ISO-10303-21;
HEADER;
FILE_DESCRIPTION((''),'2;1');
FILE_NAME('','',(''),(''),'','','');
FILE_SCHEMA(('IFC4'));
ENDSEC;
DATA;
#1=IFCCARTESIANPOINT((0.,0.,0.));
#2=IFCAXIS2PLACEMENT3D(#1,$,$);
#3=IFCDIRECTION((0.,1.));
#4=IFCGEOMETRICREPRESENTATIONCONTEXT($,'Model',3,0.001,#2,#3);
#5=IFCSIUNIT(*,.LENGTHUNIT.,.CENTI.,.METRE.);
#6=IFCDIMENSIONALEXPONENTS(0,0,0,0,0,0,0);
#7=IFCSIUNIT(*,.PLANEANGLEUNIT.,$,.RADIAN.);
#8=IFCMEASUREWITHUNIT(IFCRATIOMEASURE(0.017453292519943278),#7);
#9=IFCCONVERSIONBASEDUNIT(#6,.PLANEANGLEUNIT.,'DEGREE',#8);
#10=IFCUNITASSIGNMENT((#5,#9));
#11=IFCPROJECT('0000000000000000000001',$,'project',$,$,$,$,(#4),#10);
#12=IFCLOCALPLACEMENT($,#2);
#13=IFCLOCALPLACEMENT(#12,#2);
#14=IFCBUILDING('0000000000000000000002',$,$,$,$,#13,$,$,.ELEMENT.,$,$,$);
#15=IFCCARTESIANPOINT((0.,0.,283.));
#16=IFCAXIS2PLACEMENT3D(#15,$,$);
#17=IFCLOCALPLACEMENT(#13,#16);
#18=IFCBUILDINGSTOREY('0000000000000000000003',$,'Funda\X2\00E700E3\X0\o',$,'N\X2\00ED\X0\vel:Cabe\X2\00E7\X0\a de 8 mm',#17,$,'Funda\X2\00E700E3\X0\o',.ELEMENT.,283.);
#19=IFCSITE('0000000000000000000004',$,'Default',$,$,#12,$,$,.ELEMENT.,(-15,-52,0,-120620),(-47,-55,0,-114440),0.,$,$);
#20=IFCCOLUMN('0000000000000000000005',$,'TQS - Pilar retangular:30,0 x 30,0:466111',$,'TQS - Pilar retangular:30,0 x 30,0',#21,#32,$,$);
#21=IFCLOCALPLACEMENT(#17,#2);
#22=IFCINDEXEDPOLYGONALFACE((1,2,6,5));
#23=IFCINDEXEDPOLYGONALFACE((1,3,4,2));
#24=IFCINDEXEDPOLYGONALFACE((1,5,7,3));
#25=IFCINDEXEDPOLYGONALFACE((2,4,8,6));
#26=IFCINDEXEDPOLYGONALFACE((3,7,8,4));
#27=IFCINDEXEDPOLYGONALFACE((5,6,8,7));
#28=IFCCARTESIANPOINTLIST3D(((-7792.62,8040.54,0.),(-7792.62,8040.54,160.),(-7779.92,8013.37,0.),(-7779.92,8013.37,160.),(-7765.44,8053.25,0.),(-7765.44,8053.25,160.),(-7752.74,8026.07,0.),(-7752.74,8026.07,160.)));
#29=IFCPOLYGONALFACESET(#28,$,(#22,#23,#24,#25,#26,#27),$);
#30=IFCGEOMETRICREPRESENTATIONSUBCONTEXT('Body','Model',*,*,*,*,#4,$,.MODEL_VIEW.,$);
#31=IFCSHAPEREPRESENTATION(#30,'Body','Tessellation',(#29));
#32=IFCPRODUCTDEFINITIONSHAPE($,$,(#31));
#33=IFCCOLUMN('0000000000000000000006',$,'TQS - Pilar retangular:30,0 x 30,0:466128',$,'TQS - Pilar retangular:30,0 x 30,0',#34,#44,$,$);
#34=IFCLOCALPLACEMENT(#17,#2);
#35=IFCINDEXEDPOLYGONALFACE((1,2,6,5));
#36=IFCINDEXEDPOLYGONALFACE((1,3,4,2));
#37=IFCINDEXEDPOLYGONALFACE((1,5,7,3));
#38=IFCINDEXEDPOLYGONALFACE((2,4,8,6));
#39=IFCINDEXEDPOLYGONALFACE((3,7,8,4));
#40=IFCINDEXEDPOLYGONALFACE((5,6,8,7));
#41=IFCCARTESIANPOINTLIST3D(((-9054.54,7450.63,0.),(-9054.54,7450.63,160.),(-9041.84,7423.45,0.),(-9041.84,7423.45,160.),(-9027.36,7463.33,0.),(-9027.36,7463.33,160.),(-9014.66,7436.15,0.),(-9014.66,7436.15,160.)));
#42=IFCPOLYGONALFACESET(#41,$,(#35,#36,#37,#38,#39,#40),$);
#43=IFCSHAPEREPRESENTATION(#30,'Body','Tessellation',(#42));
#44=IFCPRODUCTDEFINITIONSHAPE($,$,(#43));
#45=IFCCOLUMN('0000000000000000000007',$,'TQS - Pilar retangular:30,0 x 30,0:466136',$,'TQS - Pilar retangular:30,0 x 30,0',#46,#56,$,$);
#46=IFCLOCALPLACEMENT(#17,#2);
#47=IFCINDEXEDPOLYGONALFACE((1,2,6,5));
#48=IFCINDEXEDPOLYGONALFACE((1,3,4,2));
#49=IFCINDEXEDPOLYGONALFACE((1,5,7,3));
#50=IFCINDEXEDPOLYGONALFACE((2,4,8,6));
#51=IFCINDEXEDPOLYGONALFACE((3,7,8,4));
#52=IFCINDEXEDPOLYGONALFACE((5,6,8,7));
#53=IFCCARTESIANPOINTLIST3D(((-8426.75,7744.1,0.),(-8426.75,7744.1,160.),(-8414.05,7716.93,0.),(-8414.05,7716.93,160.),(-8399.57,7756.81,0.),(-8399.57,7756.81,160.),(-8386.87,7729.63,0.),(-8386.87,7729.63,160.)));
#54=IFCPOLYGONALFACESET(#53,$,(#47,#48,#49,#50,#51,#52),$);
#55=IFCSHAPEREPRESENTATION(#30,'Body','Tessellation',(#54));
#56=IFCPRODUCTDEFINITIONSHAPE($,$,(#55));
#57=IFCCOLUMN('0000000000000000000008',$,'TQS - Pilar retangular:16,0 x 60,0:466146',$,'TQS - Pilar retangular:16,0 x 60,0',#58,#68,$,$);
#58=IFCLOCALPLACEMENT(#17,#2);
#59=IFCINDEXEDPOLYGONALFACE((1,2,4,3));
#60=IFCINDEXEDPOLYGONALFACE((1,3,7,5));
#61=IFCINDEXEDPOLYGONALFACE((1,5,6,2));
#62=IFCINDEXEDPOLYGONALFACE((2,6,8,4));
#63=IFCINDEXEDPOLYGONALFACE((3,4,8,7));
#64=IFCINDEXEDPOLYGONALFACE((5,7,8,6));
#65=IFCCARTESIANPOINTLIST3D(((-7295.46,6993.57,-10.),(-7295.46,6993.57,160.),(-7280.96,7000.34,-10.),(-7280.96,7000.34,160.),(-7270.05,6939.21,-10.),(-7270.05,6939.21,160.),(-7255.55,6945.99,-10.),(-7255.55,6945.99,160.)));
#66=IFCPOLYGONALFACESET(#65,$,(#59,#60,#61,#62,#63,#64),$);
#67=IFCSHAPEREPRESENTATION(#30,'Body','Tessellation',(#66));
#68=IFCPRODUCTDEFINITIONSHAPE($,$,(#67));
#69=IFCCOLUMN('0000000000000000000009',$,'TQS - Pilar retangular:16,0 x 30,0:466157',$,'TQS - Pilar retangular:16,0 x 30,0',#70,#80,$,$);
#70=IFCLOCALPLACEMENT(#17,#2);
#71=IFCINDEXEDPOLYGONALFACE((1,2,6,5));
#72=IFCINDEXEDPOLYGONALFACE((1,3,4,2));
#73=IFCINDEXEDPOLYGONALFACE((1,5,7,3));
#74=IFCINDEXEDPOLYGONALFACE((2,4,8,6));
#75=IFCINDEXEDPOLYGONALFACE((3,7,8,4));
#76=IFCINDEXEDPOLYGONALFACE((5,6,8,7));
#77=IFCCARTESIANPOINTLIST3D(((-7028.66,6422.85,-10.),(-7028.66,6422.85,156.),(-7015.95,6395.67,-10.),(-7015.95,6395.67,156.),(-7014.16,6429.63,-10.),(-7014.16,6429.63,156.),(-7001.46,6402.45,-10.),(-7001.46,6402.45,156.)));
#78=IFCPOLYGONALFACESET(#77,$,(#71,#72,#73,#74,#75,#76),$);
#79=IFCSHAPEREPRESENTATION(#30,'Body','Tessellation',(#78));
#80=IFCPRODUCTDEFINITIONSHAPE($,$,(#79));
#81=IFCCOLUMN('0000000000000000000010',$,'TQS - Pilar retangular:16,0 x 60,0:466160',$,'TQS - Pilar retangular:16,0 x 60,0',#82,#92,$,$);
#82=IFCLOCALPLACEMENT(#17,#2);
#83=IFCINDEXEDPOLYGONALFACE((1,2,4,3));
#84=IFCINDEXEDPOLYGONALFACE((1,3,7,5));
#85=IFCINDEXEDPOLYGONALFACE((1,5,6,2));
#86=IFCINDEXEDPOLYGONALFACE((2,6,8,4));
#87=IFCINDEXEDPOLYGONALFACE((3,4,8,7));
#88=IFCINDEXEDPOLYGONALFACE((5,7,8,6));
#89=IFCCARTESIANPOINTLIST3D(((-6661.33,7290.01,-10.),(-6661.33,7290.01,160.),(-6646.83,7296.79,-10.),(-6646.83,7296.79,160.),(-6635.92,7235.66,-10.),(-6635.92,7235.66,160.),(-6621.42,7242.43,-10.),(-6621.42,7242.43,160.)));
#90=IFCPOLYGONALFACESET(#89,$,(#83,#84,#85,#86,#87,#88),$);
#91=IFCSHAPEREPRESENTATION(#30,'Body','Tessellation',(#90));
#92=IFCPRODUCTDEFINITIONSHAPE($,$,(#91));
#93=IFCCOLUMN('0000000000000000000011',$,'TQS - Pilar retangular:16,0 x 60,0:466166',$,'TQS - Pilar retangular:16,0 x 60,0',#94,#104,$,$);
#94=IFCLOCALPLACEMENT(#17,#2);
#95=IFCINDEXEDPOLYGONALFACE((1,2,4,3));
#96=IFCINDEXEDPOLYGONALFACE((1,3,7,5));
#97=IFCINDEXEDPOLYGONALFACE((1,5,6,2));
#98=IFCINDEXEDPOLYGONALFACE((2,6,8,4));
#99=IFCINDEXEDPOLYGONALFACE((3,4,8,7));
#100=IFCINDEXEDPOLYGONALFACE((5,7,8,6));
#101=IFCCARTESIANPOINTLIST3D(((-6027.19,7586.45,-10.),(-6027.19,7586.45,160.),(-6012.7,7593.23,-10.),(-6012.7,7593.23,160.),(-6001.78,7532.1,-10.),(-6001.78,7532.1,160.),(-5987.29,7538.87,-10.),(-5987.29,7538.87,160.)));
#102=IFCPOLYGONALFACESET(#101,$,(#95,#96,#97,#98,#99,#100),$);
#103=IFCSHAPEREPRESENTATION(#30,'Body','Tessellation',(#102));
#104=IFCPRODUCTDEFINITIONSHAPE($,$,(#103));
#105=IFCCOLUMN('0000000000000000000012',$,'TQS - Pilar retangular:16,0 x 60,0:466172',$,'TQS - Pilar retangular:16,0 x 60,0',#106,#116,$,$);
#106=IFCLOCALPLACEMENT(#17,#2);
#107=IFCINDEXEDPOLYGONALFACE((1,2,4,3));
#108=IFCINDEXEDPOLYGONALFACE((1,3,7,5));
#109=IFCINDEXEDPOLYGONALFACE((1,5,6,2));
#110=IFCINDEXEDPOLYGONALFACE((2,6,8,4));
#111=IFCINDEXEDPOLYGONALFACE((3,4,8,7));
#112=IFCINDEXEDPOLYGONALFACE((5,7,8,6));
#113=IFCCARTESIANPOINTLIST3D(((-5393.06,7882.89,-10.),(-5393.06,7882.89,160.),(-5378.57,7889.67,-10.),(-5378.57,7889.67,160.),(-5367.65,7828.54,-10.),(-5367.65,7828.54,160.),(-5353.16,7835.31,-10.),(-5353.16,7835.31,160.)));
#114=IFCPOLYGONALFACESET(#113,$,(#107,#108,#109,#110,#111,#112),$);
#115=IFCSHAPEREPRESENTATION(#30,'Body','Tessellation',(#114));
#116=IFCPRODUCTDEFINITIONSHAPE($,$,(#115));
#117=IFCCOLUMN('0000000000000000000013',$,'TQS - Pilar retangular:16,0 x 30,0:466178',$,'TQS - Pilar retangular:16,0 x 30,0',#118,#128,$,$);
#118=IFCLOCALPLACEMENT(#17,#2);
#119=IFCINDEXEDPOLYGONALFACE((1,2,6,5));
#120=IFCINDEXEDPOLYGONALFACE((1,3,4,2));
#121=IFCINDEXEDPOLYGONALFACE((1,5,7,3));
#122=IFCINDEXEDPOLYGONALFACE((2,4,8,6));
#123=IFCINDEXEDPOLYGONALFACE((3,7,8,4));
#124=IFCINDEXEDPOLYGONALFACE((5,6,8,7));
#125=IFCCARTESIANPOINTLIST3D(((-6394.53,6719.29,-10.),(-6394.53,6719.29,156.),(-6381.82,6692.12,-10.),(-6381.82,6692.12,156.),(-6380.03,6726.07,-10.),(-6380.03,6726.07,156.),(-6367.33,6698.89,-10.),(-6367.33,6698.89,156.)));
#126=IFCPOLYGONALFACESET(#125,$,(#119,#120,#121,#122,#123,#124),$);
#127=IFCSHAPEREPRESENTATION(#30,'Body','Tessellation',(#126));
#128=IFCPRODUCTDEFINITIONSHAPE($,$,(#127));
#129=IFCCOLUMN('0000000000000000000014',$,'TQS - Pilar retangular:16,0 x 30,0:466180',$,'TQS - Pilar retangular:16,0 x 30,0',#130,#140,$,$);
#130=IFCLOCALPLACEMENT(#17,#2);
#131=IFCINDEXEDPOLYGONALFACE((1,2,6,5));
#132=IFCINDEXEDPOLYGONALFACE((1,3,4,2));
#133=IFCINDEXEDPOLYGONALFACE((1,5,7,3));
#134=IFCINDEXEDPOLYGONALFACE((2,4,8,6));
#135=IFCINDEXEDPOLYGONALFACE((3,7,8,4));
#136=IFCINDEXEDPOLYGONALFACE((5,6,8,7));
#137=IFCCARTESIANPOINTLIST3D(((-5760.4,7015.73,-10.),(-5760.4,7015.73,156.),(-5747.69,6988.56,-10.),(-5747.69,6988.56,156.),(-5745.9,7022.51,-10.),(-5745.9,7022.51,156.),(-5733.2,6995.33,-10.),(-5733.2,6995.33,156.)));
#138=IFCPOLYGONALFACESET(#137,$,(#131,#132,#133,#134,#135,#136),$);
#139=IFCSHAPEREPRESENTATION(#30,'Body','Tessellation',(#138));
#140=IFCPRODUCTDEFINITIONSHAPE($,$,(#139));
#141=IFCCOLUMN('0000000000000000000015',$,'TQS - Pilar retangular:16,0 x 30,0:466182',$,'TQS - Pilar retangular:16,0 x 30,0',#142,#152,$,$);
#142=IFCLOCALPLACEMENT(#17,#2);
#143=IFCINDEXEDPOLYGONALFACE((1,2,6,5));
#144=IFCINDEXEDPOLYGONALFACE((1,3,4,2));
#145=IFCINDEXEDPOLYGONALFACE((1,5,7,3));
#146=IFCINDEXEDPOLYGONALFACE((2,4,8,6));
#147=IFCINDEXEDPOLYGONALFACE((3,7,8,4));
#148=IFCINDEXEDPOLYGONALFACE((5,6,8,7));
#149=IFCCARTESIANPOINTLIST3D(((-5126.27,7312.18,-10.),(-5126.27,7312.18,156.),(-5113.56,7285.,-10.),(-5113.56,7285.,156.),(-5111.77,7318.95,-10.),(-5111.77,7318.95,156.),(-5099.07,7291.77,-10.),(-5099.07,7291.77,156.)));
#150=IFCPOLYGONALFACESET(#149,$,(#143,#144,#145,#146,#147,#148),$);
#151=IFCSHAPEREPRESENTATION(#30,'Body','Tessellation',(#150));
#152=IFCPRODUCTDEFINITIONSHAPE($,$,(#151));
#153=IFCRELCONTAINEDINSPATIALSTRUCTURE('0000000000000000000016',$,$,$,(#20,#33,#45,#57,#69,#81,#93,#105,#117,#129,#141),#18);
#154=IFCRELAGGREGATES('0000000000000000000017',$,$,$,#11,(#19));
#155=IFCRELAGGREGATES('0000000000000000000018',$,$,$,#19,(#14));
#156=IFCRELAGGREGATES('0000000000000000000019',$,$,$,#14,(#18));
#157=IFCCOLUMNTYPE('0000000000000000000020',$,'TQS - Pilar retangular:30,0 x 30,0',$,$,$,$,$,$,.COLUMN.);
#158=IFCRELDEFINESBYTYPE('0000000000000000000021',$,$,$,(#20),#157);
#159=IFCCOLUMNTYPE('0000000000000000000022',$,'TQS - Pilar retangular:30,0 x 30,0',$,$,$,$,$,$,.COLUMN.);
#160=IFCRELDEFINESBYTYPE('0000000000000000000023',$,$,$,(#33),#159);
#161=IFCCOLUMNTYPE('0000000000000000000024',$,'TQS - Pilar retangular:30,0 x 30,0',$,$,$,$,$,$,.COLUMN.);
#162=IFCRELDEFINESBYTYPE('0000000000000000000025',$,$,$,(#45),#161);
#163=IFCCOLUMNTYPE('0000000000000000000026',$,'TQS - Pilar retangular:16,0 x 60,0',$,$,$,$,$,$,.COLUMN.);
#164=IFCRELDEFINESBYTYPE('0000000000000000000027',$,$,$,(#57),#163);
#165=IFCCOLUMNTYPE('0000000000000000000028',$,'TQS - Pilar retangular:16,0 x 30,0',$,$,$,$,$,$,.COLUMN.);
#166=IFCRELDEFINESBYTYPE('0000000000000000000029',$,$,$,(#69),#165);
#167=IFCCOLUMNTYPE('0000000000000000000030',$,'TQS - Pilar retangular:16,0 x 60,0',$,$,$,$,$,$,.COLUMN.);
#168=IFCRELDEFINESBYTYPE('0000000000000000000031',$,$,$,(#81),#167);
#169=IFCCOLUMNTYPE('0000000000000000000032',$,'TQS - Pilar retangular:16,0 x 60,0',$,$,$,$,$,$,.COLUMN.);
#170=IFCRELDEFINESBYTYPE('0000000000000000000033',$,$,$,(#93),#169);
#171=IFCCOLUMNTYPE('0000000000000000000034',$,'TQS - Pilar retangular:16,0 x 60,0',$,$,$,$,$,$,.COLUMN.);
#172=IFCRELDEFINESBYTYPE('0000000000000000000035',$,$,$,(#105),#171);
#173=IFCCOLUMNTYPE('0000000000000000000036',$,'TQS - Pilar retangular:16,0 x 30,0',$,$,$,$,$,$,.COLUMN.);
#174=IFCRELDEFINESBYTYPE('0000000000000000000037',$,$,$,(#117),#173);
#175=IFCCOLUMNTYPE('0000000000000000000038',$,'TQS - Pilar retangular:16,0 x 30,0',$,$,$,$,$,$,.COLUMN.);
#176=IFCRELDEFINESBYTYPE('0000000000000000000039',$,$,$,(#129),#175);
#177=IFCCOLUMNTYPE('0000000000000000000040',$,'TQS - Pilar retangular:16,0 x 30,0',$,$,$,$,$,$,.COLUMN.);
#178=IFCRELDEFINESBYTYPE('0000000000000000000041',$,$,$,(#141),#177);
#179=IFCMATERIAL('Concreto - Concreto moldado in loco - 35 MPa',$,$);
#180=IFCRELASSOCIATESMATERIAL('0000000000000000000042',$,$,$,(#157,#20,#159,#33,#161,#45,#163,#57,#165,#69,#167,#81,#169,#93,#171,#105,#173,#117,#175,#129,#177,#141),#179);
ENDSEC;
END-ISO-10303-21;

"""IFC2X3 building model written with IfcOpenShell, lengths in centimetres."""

from ifc_helpers import new_model, entity, si_unit, converted_unit, direction, frame, frame_2d, origin, origin_2d_with_axis, place, context, subcontext, project, spatial, rectangle, extrude, source, transform, mapped, material, type_object, type_shapes, element, save


model = new_model("IFC2X3")

# Units and contexts
model_context = context("Model", 3, precision=0.001, world=origin(), true_north=direction((0.0, 1.0)))
body_context = subcontext(model_context, "Body", "Model", "MODEL_VIEW")
ifc_project = project(units=[si_unit("LENGTHUNIT", "METRE", prefix="CENTI"), converted_unit("PLANEANGLEUNIT", "DEGREE", entity("IfcRatioMeasure", 0.017453292519943278), si_unit("PLANEANGLEUNIT", "RADIAN"), dimensions=[0, 0, 0, 0, 0, 0, 0])], contexts=[model_context])

# Site, building, storey
site_placement = place(None, origin())
site = spatial("IfcSite", under=ifc_project, at=site_placement, Name="Default", CompositionType="ELEMENT", RefLatitude=(-15, -52, 0, -120620), RefLongitude=(-47, -55, 0, -114440), RefElevation=0.0)
building_placement = place(site_placement, origin())
building = spatial("IfcBuilding", under=site, at=building_placement, CompositionType="ELEMENT")
storey_placement = place(building_placement, frame((0.0, 0.0, 283.0)))
storey = spatial("IfcBuildingStorey", under=building, at=storey_placement, Name="Fundação", ObjectType="Nível:Cabeça de 8 mm", LongName="Fundação", CompositionType="ELEMENT", Elevation=283.0)

# Columns
ifc_material_1 = material(Name="Concreto - Concreto moldado in loco - 35 MPa")
column_type_1 = type_object("IfcColumnType", Name="TQS - Pilar retangular:30,0 x 30,0", PredefinedType="COLUMN", material=ifc_material_1)
shared_shape_1 = source(origin(), body_context, "Body", "SweptSolid", [
    extrude(rectangle(XDim=30.0, YDim=30.0, at=origin_2d_with_axis()), frame((-7772.68, 8033.31, 283.0), z_axis=(0.0, 0.0, 1.0), x_axis=(-0.423488, 0.905902, 0.0)), (0.0, 0.0, 1.0), 160.0),
])
type_shapes(column_type_1, [shared_shape_1])
column_1_placement = place(storey_placement, frame((0.0, 0.0, -283.0)))
element("IfcColumn", 1, at=column_1_placement, inside=storey, type_object=column_type_1, material=ifc_material_1, Name="TQS - Pilar retangular:30,0 x 30,0:466111", ObjectType="TQS - Pilar retangular:30,0 x 30,0", context=body_context, shape_type="MappedRepresentation", body=[
    mapped(shared_shape_1, transform((0.0, 0.0, 0.0), scale=1.0)),
])
column_type_2 = type_object("IfcColumnType", Name="TQS - Pilar retangular:30,0 x 30,0", PredefinedType="COLUMN", material=ifc_material_1)
shared_shape_2 = source(origin(), body_context, "Body", "SweptSolid", [
    extrude(rectangle(XDim=30.0, YDim=30.0, at=origin_2d_with_axis()), frame((-9034.6, 7443.39, 283.0), z_axis=(0.0, 0.0, 1.0), x_axis=(-0.423488, 0.905902, 0.0)), (0.0, 0.0, 1.0), 160.0),
])
type_shapes(column_type_2, [shared_shape_2])
column_2_placement = place(storey_placement, frame((0.0, 0.0, -283.0)))
element("IfcColumn", 2, at=column_2_placement, inside=storey, type_object=column_type_2, material=ifc_material_1, Name="TQS - Pilar retangular:30,0 x 30,0:466128", ObjectType="TQS - Pilar retangular:30,0 x 30,0", context=body_context, shape_type="MappedRepresentation", body=[
    mapped(shared_shape_2, transform((0.0, 0.0, 0.0), scale=1.0)),
])
column_type_3 = type_object("IfcColumnType", Name="TQS - Pilar retangular:30,0 x 30,0", PredefinedType="COLUMN", material=ifc_material_1)
shared_shape_3 = source(origin(), body_context, "Body", "SweptSolid", [
    extrude(rectangle(XDim=30.0, YDim=30.0, at=origin_2d_with_axis()), frame((-8406.81, 7736.87, 283.0), z_axis=(0.0, 0.0, 1.0), x_axis=(-0.423488, 0.905902, 0.0)), (0.0, 0.0, 1.0), 160.0),
])
type_shapes(column_type_3, [shared_shape_3])
column_3_placement = place(storey_placement, frame((0.0, 0.0, -283.0)))
element("IfcColumn", 3, at=column_3_placement, inside=storey, type_object=column_type_3, material=ifc_material_1, Name="TQS - Pilar retangular:30,0 x 30,0:466136", ObjectType="TQS - Pilar retangular:30,0 x 30,0", context=body_context, shape_type="MappedRepresentation", body=[
    mapped(shared_shape_3, transform((0.0, 0.0, 0.0), scale=1.0)),
])
column_type_4 = type_object("IfcColumnType", Name="TQS - Pilar retangular:16,0 x 60,0", PredefinedType="COLUMN", material=ifc_material_1)
shared_shape_4 = source(origin(), body_context, "Body", "SweptSolid", [
    extrude(rectangle(XDim=60.0, YDim=16.0, at=frame_2d((0.0, 0.0), x_axis=(1.0, 0.0))), frame((-7275.5, 6969.78, 273.0), z_axis=(0.0, 0.0, 1.0), x_axis=(-0.423488, 0.905902, 0.0)), (0.0, 0.0, 1.0), 170.0),
])
type_shapes(column_type_4, [shared_shape_4])
column_4_placement = place(storey_placement, frame((0.0, 0.0, -283.0)))
element("IfcColumn", 4, at=column_4_placement, inside=storey, type_object=column_type_4, material=ifc_material_1, Name="TQS - Pilar retangular:16,0 x 60,0:466146", ObjectType="TQS - Pilar retangular:16,0 x 60,0", context=body_context, shape_type="MappedRepresentation", body=[
    mapped(shared_shape_4, transform((0.0, 0.0, 0.0), scale=1.0)),
])
column_type_5 = type_object("IfcColumnType", Name="TQS - Pilar retangular:16,0 x 30,0", PredefinedType="COLUMN", material=ifc_material_1)
shared_shape_5 = source(origin(), body_context, "Body", "SweptSolid", [
    extrude(rectangle(XDim=30.0, YDim=16.0, at=frame_2d((0.0, 0.0), x_axis=(1.0, 0.0))), frame((-7015.06, 6412.65, 273.0), z_axis=(0.0, 0.0, 1.0), x_axis=(-0.423488, 0.905902, 0.0)), (0.0, 0.0, 1.0), 166.0),
])
type_shapes(column_type_5, [shared_shape_5])
column_5_placement = place(storey_placement, frame((0.0, 0.0, -283.0)))
element("IfcColumn", 5, at=column_5_placement, inside=storey, type_object=column_type_5, material=ifc_material_1, Name="TQS - Pilar retangular:16,0 x 30,0:466157", ObjectType="TQS - Pilar retangular:16,0 x 30,0", context=body_context, shape_type="MappedRepresentation", body=[
    mapped(shared_shape_5, transform((0.0, 0.0, 0.0), scale=1.0)),
])
column_type_6 = type_object("IfcColumnType", Name="TQS - Pilar retangular:16,0 x 60,0", PredefinedType="COLUMN", material=ifc_material_1)
shared_shape_6 = source(origin(), body_context, "Body", "SweptSolid", [
    extrude(rectangle(XDim=60.0, YDim=16.0, at=frame_2d((0.0, 0.0), x_axis=(1.0, 0.0))), frame((-6641.37, 7266.22, 273.0), z_axis=(0.0, 0.0, 1.0), x_axis=(-0.423488, 0.905902, 0.0)), (0.0, 0.0, 1.0), 170.0),
])
type_shapes(column_type_6, [shared_shape_6])
column_6_placement = place(storey_placement, frame((0.0, 0.0, -283.0)))
element("IfcColumn", 6, at=column_6_placement, inside=storey, type_object=column_type_6, material=ifc_material_1, Name="TQS - Pilar retangular:16,0 x 60,0:466160", ObjectType="TQS - Pilar retangular:16,0 x 60,0", context=body_context, shape_type="MappedRepresentation", body=[
    mapped(shared_shape_6, transform((0.0, 0.0, 0.0), scale=1.0)),
])
column_type_7 = type_object("IfcColumnType", Name="TQS - Pilar retangular:16,0 x 60,0", PredefinedType="COLUMN", material=ifc_material_1)
shared_shape_7 = source(origin(), body_context, "Body", "SweptSolid", [
    extrude(rectangle(XDim=60.0, YDim=16.0, at=origin_2d_with_axis()), frame((-6007.24, 7562.66, 273.0), z_axis=(0.0, 0.0, 1.0), x_axis=(-0.423488, 0.905902, 0.0)), (0.0, 0.0, 1.0), 170.0),
])
type_shapes(column_type_7, [shared_shape_7])
column_7_placement = place(storey_placement, frame((0.0, 0.0, -283.0)))
element("IfcColumn", 7, at=column_7_placement, inside=storey, type_object=column_type_7, material=ifc_material_1, Name="TQS - Pilar retangular:16,0 x 60,0:466166", ObjectType="TQS - Pilar retangular:16,0 x 60,0", context=body_context, shape_type="MappedRepresentation", body=[
    mapped(shared_shape_7, transform((0.0, 0.0, 0.0), scale=1.0)),
])
column_type_8 = type_object("IfcColumnType", Name="TQS - Pilar retangular:16,0 x 60,0", PredefinedType="COLUMN", material=ifc_material_1)
shared_shape_8 = source(origin(), body_context, "Body", "SweptSolid", [
    extrude(rectangle(XDim=60.0, YDim=16.0, at=origin_2d_with_axis()), frame((-5373.11, 7859.1, 273.0), z_axis=(0.0, 0.0, 1.0), x_axis=(-0.423488, 0.905902, 0.0)), (0.0, 0.0, 1.0), 170.0),
])
type_shapes(column_type_8, [shared_shape_8])
column_8_placement = place(storey_placement, frame((0.0, 0.0, -283.0)))
element("IfcColumn", 8, at=column_8_placement, inside=storey, type_object=column_type_8, material=ifc_material_1, Name="TQS - Pilar retangular:16,0 x 60,0:466172", ObjectType="TQS - Pilar retangular:16,0 x 60,0", context=body_context, shape_type="MappedRepresentation", body=[
    mapped(shared_shape_8, transform((0.0, 0.0, 0.0), scale=1.0)),
])
column_type_9 = type_object("IfcColumnType", Name="TQS - Pilar retangular:16,0 x 30,0", PredefinedType="COLUMN", material=ifc_material_1)
shared_shape_9 = source(origin(), body_context, "Body", "SweptSolid", [
    extrude(rectangle(XDim=30.0, YDim=16.0, at=frame_2d((0.0, 0.0), x_axis=(1.0, 0.0))), frame((-6380.93, 6709.09, 273.0), z_axis=(0.0, 0.0, 1.0), x_axis=(-0.423488, 0.905902, 0.0)), (0.0, 0.0, 1.0), 166.0),
])
type_shapes(column_type_9, [shared_shape_9])
column_9_placement = place(storey_placement, frame((0.0, 0.0, -283.0)))
element("IfcColumn", 9, at=column_9_placement, inside=storey, type_object=column_type_9, material=ifc_material_1, Name="TQS - Pilar retangular:16,0 x 30,0:466178", ObjectType="TQS - Pilar retangular:16,0 x 30,0", context=body_context, shape_type="MappedRepresentation", body=[
    mapped(shared_shape_9, transform((0.0, 0.0, 0.0), scale=1.0)),
])
column_type_10 = type_object("IfcColumnType", Name="TQS - Pilar retangular:16,0 x 30,0", PredefinedType="COLUMN", material=ifc_material_1)
shared_shape_10 = source(origin(), body_context, "Body", "SweptSolid", [
    extrude(rectangle(XDim=30.0, YDim=16.0, at=origin_2d_with_axis()), frame((-5746.8, 7005.53, 273.0), z_axis=(0.0, 0.0, 1.0), x_axis=(-0.423488, 0.905902, 0.0)), (0.0, 0.0, 1.0), 166.0),
])
type_shapes(column_type_10, [shared_shape_10])
column_10_placement = place(storey_placement, frame((0.0, 0.0, -283.0)))
element("IfcColumn", 10, at=column_10_placement, inside=storey, type_object=column_type_10, material=ifc_material_1, Name="TQS - Pilar retangular:16,0 x 30,0:466180", ObjectType="TQS - Pilar retangular:16,0 x 30,0", context=body_context, shape_type="MappedRepresentation", body=[
    mapped(shared_shape_10, transform((0.0, 0.0, 0.0), scale=1.0)),
])
column_type_11 = type_object("IfcColumnType", Name="TQS - Pilar retangular:16,0 x 30,0", PredefinedType="COLUMN", material=ifc_material_1)
shared_shape_11 = source(origin(), body_context, "Body", "SweptSolid", [
    extrude(rectangle(XDim=30.0, YDim=16.0, at=origin_2d_with_axis()), frame((-5112.67, 7301.97, 273.0), z_axis=(0.0, 0.0, 1.0), x_axis=(-0.423488, 0.905902, 0.0)), (0.0, 0.0, 1.0), 166.0),
])
type_shapes(column_type_11, [shared_shape_11])
column_11_placement = place(storey_placement, frame((0.0, 0.0, -283.0)))
element("IfcColumn", 11, at=column_11_placement, inside=storey, type_object=column_type_11, material=ifc_material_1, Name="TQS - Pilar retangular:16,0 x 30,0:466182", ObjectType="TQS - Pilar retangular:16,0 x 30,0", context=body_context, shape_type="MappedRepresentation", body=[
    mapped(shared_shape_11, transform((0.0, 0.0, 0.0), scale=1.0)),
])

save(model, "model.ifc")
